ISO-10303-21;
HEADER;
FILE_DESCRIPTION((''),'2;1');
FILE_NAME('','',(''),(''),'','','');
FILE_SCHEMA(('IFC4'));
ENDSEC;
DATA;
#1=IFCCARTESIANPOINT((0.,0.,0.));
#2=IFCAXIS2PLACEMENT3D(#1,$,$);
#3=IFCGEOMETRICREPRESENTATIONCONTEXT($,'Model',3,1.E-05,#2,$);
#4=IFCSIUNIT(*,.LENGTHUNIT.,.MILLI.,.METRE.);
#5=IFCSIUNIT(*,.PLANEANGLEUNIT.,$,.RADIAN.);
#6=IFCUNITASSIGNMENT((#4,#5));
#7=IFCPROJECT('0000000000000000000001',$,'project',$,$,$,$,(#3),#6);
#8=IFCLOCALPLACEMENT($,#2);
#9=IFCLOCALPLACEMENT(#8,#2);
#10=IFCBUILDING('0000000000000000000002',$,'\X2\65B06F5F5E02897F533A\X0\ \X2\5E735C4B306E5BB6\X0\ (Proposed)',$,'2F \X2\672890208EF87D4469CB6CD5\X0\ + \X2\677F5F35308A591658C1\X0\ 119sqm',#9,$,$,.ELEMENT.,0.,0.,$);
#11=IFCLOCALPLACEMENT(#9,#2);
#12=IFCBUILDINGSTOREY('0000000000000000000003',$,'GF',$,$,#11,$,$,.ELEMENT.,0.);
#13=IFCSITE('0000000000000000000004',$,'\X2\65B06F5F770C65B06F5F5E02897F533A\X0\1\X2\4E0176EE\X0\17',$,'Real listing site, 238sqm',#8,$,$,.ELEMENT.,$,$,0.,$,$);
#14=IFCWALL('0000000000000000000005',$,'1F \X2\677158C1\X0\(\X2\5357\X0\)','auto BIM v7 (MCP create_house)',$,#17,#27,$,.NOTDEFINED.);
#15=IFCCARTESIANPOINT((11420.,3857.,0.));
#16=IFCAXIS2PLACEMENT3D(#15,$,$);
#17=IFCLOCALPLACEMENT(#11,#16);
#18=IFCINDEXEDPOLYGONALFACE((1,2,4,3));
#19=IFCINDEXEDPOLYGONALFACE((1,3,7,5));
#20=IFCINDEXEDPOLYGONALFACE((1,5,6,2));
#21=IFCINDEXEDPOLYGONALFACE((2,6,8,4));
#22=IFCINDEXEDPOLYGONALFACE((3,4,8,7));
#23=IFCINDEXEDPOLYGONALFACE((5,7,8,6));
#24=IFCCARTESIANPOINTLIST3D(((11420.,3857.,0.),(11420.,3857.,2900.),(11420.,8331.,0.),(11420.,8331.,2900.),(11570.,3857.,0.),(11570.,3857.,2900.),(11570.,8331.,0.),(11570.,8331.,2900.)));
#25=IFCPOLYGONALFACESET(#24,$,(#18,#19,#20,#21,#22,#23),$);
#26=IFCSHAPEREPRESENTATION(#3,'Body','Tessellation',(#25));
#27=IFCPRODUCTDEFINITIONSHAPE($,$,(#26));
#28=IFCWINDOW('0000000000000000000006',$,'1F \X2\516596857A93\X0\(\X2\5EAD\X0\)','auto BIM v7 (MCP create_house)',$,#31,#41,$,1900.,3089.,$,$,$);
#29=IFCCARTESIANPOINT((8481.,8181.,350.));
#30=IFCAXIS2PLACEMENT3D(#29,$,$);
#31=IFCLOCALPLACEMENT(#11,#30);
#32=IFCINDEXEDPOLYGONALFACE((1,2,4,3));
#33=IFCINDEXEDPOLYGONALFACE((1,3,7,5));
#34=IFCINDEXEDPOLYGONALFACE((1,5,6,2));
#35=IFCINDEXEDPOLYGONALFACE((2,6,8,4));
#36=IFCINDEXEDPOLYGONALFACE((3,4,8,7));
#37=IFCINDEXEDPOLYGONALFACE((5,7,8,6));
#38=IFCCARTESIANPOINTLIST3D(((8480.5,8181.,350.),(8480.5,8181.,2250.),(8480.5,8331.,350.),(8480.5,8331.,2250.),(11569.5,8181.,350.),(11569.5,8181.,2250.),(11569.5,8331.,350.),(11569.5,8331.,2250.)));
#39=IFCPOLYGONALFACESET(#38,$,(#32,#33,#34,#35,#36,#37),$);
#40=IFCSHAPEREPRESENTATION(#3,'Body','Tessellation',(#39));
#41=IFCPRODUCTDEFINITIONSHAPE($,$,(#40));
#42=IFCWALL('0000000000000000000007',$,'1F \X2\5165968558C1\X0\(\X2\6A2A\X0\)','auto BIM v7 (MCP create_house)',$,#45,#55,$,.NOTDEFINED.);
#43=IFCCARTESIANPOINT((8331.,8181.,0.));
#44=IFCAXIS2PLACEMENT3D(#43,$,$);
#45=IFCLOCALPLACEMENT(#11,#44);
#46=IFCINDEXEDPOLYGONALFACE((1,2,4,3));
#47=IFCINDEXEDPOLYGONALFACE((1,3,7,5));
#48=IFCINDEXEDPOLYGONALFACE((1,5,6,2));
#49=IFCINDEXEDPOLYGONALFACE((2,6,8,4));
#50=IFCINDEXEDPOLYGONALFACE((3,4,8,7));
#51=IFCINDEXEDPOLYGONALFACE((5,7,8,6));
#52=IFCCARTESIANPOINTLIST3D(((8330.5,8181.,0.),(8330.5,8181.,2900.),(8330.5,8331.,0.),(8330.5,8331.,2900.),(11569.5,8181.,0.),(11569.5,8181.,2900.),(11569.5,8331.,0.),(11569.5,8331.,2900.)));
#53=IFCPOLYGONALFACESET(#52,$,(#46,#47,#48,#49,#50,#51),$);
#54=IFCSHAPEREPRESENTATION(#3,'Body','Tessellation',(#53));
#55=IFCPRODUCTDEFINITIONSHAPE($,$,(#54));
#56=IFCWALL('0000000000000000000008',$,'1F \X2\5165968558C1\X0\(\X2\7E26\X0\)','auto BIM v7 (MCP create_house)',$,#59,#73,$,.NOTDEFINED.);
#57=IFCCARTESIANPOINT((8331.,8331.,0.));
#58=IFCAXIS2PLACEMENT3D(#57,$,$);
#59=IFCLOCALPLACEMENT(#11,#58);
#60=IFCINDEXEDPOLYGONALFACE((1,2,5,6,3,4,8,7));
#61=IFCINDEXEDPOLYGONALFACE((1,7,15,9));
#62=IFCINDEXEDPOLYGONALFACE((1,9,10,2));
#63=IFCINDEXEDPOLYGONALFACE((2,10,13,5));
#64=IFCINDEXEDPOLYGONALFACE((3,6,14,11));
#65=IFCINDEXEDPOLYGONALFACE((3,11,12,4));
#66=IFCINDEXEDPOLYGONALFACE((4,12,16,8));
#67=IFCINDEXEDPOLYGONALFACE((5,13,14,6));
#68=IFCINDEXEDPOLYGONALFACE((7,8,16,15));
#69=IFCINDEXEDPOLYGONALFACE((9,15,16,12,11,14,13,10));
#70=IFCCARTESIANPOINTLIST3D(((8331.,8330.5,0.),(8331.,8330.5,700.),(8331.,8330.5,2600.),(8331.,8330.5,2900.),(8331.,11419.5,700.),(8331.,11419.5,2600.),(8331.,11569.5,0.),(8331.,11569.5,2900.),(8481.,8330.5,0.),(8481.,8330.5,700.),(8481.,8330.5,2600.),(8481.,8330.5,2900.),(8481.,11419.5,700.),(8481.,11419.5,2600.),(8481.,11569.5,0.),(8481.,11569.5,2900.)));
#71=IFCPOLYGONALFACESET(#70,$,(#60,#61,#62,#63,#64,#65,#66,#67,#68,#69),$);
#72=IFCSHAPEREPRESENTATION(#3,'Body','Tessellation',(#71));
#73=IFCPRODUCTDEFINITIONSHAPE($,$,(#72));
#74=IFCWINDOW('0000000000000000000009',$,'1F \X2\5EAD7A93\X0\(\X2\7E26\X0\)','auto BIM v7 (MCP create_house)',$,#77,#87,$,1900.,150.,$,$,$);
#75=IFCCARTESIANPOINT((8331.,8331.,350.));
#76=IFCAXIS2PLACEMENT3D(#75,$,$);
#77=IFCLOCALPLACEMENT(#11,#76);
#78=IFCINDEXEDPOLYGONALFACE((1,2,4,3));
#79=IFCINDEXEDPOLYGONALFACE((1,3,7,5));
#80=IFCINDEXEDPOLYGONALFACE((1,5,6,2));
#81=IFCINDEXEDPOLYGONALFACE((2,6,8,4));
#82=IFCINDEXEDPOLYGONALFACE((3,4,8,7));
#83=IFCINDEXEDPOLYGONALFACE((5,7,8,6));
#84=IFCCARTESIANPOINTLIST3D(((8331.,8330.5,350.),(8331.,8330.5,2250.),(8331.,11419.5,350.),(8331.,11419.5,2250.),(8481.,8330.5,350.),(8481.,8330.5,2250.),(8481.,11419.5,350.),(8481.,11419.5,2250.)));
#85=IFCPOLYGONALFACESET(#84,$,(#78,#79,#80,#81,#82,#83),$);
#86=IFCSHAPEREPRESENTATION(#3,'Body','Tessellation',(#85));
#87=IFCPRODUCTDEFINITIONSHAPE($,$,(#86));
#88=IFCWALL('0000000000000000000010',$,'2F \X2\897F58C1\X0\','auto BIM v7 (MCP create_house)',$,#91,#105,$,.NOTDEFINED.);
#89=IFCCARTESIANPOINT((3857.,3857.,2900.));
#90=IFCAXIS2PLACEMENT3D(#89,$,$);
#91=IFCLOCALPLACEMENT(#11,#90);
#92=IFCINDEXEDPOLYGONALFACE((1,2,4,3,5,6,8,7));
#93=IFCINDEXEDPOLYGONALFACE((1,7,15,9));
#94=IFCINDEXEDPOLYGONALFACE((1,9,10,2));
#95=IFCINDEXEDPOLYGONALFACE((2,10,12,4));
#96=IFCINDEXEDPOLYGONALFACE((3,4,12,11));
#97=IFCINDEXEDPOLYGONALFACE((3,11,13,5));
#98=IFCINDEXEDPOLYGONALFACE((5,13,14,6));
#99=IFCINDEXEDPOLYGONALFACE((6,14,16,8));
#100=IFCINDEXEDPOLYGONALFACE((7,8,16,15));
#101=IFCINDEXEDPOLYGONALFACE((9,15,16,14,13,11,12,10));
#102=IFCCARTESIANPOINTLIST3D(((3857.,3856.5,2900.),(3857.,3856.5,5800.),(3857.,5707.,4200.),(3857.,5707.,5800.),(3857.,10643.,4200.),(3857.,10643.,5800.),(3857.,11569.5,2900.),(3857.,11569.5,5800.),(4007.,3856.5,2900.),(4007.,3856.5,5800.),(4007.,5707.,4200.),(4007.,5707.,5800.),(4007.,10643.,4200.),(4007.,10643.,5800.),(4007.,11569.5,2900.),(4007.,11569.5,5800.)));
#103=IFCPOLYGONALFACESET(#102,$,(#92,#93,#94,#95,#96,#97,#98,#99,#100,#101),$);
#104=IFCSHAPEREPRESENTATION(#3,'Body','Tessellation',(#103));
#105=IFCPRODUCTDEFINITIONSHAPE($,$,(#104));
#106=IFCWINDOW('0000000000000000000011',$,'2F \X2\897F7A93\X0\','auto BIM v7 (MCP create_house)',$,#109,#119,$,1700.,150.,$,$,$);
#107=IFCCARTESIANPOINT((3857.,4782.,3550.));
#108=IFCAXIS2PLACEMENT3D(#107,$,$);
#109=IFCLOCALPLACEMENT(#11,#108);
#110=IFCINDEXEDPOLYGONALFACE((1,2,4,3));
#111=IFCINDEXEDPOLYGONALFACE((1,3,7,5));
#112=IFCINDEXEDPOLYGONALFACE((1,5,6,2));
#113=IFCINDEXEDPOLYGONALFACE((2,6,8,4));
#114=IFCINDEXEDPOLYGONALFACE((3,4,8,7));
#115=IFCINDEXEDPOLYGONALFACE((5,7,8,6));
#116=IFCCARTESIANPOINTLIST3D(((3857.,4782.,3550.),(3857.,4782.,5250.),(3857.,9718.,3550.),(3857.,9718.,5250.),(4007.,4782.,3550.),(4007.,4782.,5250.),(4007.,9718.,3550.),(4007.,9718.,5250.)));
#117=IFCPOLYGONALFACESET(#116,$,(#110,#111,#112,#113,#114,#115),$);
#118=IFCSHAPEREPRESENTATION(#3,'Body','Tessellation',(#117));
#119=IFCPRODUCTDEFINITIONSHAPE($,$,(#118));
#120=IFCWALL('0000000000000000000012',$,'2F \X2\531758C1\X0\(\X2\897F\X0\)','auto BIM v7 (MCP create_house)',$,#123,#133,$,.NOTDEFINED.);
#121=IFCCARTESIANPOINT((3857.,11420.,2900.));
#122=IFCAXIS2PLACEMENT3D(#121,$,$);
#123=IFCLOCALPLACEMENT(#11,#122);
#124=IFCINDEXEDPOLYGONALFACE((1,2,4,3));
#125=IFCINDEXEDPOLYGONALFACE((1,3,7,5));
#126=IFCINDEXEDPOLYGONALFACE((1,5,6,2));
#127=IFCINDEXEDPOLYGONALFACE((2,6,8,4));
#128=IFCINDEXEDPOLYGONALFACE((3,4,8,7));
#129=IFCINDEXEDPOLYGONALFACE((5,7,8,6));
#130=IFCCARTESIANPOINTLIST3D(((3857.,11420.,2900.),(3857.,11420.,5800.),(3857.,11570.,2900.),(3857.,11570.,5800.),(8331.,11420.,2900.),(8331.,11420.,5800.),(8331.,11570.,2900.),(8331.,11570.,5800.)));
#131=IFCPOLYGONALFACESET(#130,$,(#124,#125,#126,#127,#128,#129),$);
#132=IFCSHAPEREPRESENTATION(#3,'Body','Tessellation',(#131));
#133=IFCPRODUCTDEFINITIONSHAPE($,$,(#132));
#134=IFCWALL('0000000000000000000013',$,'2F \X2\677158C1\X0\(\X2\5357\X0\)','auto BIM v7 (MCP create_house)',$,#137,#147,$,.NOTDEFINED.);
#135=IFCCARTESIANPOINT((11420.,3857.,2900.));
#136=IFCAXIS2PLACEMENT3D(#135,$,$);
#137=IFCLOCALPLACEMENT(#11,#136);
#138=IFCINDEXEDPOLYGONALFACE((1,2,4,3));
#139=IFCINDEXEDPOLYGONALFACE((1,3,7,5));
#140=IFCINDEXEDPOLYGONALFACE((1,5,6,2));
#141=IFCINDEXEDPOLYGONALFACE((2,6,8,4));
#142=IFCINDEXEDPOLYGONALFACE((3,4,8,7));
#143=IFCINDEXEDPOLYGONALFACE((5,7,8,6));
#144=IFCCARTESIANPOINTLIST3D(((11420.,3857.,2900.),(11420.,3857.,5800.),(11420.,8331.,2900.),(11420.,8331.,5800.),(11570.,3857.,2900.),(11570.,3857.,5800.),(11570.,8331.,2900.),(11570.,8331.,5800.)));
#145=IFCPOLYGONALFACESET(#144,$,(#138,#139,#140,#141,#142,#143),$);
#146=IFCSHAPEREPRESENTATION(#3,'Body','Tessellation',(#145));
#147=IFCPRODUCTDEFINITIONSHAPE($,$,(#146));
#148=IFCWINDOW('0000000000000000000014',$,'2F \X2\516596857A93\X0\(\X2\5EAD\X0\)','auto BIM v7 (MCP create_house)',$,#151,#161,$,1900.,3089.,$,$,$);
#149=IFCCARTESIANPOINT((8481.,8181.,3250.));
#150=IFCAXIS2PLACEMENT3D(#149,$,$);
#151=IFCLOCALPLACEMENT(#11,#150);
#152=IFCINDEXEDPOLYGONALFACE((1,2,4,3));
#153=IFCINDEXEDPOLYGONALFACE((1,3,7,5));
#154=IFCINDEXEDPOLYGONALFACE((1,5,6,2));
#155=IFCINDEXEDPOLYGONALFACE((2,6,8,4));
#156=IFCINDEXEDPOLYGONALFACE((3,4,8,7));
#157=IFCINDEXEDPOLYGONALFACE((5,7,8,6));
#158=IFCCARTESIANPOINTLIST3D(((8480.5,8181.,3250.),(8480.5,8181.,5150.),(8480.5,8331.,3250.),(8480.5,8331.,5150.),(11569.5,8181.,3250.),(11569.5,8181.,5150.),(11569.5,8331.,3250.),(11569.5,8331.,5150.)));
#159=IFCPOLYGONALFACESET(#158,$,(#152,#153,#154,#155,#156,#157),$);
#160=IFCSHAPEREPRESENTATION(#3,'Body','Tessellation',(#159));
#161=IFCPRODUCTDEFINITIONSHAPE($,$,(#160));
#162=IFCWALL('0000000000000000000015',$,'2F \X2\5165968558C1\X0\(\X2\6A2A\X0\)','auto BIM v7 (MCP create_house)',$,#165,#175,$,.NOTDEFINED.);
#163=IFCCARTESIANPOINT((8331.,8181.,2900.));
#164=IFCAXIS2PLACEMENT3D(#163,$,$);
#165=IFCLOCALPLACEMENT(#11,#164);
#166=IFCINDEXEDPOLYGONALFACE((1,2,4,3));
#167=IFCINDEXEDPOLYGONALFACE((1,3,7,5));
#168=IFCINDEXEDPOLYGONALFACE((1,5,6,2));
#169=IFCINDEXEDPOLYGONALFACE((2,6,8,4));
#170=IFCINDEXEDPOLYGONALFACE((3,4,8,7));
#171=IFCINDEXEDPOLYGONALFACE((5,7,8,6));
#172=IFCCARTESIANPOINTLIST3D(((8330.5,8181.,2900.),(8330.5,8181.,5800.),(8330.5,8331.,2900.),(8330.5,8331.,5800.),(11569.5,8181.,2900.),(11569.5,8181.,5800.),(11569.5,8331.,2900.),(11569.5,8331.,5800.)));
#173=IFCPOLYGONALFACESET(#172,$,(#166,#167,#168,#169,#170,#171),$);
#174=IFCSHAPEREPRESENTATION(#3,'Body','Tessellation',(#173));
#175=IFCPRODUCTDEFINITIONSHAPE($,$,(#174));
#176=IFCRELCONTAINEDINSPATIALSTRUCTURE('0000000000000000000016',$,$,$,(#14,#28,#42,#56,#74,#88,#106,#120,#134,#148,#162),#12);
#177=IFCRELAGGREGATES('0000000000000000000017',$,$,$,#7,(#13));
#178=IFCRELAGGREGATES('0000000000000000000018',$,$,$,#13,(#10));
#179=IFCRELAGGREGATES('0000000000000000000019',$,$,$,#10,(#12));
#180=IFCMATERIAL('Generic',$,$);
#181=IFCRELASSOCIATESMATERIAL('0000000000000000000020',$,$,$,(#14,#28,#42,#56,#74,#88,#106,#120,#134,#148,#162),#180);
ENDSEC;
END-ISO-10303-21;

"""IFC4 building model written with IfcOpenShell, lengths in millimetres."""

from ifc_helpers import new_model, si_unit, frame, frame_2d, origin, place, context, project, spatial, rectangle, extrude, material, element, fill, save


model = new_model("IFC4")

# Units and contexts
model_context = context("Model", 3, precision=1e-05, world=origin())
ifc_project = project(units=[si_unit("LENGTHUNIT", "METRE", prefix="MILLI"), si_unit("PLANEANGLEUNIT", "RADIAN")], contexts=[model_context])

# Site, building, storey
site_placement = place(None, origin())
site = spatial("IfcSite", under=ifc_project, at=site_placement, Name="新潟県新潟市西区1丁目17", ObjectType="Real listing site, 238sqm", CompositionType="ELEMENT", RefElevation=0.0)
building_placement = place(site_placement, origin())
building = spatial("IfcBuilding", under=site, at=building_placement, Name="新潟市西区 平屋の家 (Proposed)", ObjectType="2F 木造軸組構法 + 板張り外壁 119sqm", CompositionType="ELEMENT", ElevationOfRefHeight=0.0, ElevationOfTerrain=0.0)
storey_placement = place(building_placement, origin())
storey = spatial("IfcBuildingStorey", under=building, at=storey_placement, Name="GF", CompositionType="ELEMENT", Elevation=0.0)

# Shared definitions
ifc_material = material(Name="Generic")

# Wall, opening, window
wall_1_placement = place(storey_placement, frame((11420.0, 3857.0, 0.0)))
wall_1 = element("IfcWall", 1, at=wall_1_placement, inside=storey, material=ifc_material, Name="1F 東壁(南)", Description="auto BIM v7 (MCP create_house)", PredefinedType="NOTDEFINED", context=model_context, shape_type="SweptSolid", body=[
    extrude(rectangle(XDim=150.0, YDim=4474.0, at=frame_2d((75.0, 2237.0))), frame((11420.0, 3857.0, 0.0)), (0.0, 0.0, 1.0), 2900.0),
])
opening_1_placement = place(storey_placement, frame((8481.0, 8181.0, 350.0)))
opening_1 = element("IfcOpeningElement", 2, at=opening_1_placement, cuts=wall_1, PredefinedType="NOTDEFINED", context=model_context, shape_type="SweptSolid", body=[
    extrude(rectangle(XDim=3089.0, YDim=150.0, at=frame_2d((1544.0, 75.0))), frame((8481.0, 8181.0, 350.0)), (0.0, 0.0, 1.0), 1900.0),
])
window_1_placement = place(storey_placement, frame((8481.0, 8181.0, 350.0)))
window_1 = element("IfcWindow", 3, at=window_1_placement, inside=storey, material=ifc_material, Name="1F 入隅窓(庭)", Description="auto BIM v7 (MCP create_house)", OverallHeight=1900.0, OverallWidth=3089.0, context=model_context, shape_type="SweptSolid", body=[
    extrude(rectangle(XDim=3089.0, YDim=150.0, at=frame_2d((1544.0, 75.0))), frame((8481.0, 8181.0, 350.0)), (0.0, 0.0, 1.0), 1900.0),
])
fill(opening_1, window_1)

# Wall
wall_2_placement = place(storey_placement, frame((8331.0, 8181.0, 0.0)))
element("IfcWall", 4, at=wall_2_placement, inside=storey, material=ifc_material, Name="1F 入隅壁(横)", Description="auto BIM v7 (MCP create_house)", PredefinedType="NOTDEFINED", context=model_context, shape_type="SweptSolid", body=[
    extrude(rectangle(XDim=3239.0, YDim=150.0, at=frame_2d((1619.0, 75.0))), frame((8331.0, 8181.0, 0.0)), (0.0, 0.0, 1.0), 2900.0),
])

# Wall, opening, window
wall_3_placement = place(storey_placement, frame((8331.0, 8331.0, 0.0)))
wall_3 = element("IfcWall", 5, at=wall_3_placement, inside=storey, material=ifc_material, Name="1F 入隅壁(縦)", Description="auto BIM v7 (MCP create_house)", PredefinedType="NOTDEFINED", context=model_context, shape_type="SweptSolid", body=[
    extrude(rectangle(XDim=150.0, YDim=3239.0, at=frame_2d((75.0, 1619.0))), frame((8331.0, 8331.0, 0.0)), (0.0, 0.0, 1.0), 2900.0),
])
opening_2_placement = place(storey_placement, frame((8331.0, 8331.0, 350.0)))
opening_2 = element("IfcOpeningElement", 6, at=opening_2_placement, cuts=wall_3, PredefinedType="NOTDEFINED", context=model_context, shape_type="SweptSolid", body=[
    extrude(rectangle(XDim=150.0, YDim=3089.0, at=frame_2d((75.0, 1544.0))), frame((8331.0, 8331.0, 350.0)), (0.0, 0.0, 1.0), 1900.0),
])
window_2_placement = place(storey_placement, frame((8331.0, 8331.0, 350.0)))
window_2 = element("IfcWindow", 7, at=window_2_placement, inside=storey, material=ifc_material, Name="1F 庭窓(縦)", Description="auto BIM v7 (MCP create_house)", OverallHeight=1900.0, OverallWidth=150.0, context=model_context, shape_type="SweptSolid", body=[
    extrude(rectangle(XDim=150.0, YDim=3089.0, at=frame_2d((75.0, 1544.0))), frame((8331.0, 8331.0, 350.0)), (0.0, 0.0, 1.0), 1900.0),
])
fill(opening_2, window_2)

# Wall, opening, window
wall_4_placement = place(storey_placement, frame((3857.0, 3857.0, 2900.0)))
wall_4 = element("IfcWall", 8, at=wall_4_placement, inside=storey, material=ifc_material, Name="2F 西壁", Description="auto BIM v7 (MCP create_house)", PredefinedType="NOTDEFINED", context=model_context, shape_type="SweptSolid", body=[
    extrude(rectangle(XDim=150.0, YDim=7713.0, at=frame_2d((75.0, 3856.0))), frame((3857.0, 3857.0, 2900.0)), (0.0, 0.0, 1.0), 2900.0),
])
opening_3_placement = place(storey_placement, frame((3857.0, 4782.0, 3550.0)))
opening_3 = element("IfcOpeningElement", 9, at=opening_3_placement, cuts=wall_4, PredefinedType="NOTDEFINED", context=model_context, shape_type="SweptSolid", body=[
    extrude(rectangle(XDim=150.0, YDim=4936.0, at=frame_2d((75.0, 2468.0))), frame((3857.0, 4782.0, 3550.0)), (0.0, 0.0, 1.0), 1700.0),
])
window_3_placement = place(storey_placement, frame((3857.0, 4782.0, 3550.0)))
window_3 = element("IfcWindow", 10, at=window_3_placement, inside=storey, material=ifc_material, Name="2F 西窓", Description="auto BIM v7 (MCP create_house)", OverallHeight=1700.0, OverallWidth=150.0, context=model_context, shape_type="SweptSolid", body=[
    extrude(rectangle(XDim=150.0, YDim=4936.0, at=frame_2d((75.0, 2468.0))), frame((3857.0, 4782.0, 3550.0)), (0.0, 0.0, 1.0), 1700.0),
])
fill(opening_3, window_3)

# Wall
wall_5_placement = place(storey_placement, frame((3857.0, 11420.0, 2900.0)))
element("IfcWall", 11, at=wall_5_placement, inside=storey, material=ifc_material, Name="2F 北壁(西)", Description="auto BIM v7 (MCP create_house)", PredefinedType="NOTDEFINED", context=model_context, shape_type="SweptSolid", body=[
    extrude(rectangle(XDim=4474.0, YDim=150.0, at=frame_2d((2237.0, 75.0))), frame((3857.0, 11420.0, 2900.0)), (0.0, 0.0, 1.0), 2900.0),
])

# Wall, opening, window
wall_6_placement = place(storey_placement, frame((11420.0, 3857.0, 2900.0)))
wall_6 = element("IfcWall", 12, at=wall_6_placement, inside=storey, material=ifc_material, Name="2F 東壁(南)", Description="auto BIM v7 (MCP create_house)", PredefinedType="NOTDEFINED", context=model_context, shape_type="SweptSolid", body=[
    extrude(rectangle(XDim=150.0, YDim=4474.0, at=frame_2d((75.0, 2237.0))), frame((11420.0, 3857.0, 2900.0)), (0.0, 0.0, 1.0), 2900.0),
])
opening_4_placement = place(storey_placement, frame((8481.0, 8181.0, 3250.0)))
opening_4 = element("IfcOpeningElement", 13, at=opening_4_placement, cuts=wall_6, PredefinedType="NOTDEFINED", context=model_context, shape_type="SweptSolid", body=[
    extrude(rectangle(XDim=3089.0, YDim=150.0, at=frame_2d((1544.0, 75.0))), frame((8481.0, 8181.0, 3250.0)), (0.0, 0.0, 1.0), 1900.0),
])
window_4_placement = place(storey_placement, frame((8481.0, 8181.0, 3250.0)))
window_4 = element("IfcWindow", 14, at=window_4_placement, inside=storey, material=ifc_material, Name="2F 入隅窓(庭)", Description="auto BIM v7 (MCP create_house)", OverallHeight=1900.0, OverallWidth=3089.0, context=model_context, shape_type="SweptSolid", body=[
    extrude(rectangle(XDim=3089.0, YDim=150.0, at=frame_2d((1544.0, 75.0))), frame((8481.0, 8181.0, 3250.0)), (0.0, 0.0, 1.0), 1900.0),
])
fill(opening_4, window_4)

# Wall
wall_7_placement = place(storey_placement, frame((8331.0, 8181.0, 2900.0)))
element("IfcWall", 15, at=wall_7_placement, inside=storey, material=ifc_material, Name="2F 入隅壁(横)", Description="auto BIM v7 (MCP create_house)", PredefinedType="NOTDEFINED", context=model_context, shape_type="SweptSolid", body=[
    extrude(rectangle(XDim=3239.0, YDim=150.0, at=frame_2d((1619.0, 75.0))), frame((8331.0, 8181.0, 2900.0)), (0.0, 0.0, 1.0), 2900.0),
])

save(model, "model.ifc")
